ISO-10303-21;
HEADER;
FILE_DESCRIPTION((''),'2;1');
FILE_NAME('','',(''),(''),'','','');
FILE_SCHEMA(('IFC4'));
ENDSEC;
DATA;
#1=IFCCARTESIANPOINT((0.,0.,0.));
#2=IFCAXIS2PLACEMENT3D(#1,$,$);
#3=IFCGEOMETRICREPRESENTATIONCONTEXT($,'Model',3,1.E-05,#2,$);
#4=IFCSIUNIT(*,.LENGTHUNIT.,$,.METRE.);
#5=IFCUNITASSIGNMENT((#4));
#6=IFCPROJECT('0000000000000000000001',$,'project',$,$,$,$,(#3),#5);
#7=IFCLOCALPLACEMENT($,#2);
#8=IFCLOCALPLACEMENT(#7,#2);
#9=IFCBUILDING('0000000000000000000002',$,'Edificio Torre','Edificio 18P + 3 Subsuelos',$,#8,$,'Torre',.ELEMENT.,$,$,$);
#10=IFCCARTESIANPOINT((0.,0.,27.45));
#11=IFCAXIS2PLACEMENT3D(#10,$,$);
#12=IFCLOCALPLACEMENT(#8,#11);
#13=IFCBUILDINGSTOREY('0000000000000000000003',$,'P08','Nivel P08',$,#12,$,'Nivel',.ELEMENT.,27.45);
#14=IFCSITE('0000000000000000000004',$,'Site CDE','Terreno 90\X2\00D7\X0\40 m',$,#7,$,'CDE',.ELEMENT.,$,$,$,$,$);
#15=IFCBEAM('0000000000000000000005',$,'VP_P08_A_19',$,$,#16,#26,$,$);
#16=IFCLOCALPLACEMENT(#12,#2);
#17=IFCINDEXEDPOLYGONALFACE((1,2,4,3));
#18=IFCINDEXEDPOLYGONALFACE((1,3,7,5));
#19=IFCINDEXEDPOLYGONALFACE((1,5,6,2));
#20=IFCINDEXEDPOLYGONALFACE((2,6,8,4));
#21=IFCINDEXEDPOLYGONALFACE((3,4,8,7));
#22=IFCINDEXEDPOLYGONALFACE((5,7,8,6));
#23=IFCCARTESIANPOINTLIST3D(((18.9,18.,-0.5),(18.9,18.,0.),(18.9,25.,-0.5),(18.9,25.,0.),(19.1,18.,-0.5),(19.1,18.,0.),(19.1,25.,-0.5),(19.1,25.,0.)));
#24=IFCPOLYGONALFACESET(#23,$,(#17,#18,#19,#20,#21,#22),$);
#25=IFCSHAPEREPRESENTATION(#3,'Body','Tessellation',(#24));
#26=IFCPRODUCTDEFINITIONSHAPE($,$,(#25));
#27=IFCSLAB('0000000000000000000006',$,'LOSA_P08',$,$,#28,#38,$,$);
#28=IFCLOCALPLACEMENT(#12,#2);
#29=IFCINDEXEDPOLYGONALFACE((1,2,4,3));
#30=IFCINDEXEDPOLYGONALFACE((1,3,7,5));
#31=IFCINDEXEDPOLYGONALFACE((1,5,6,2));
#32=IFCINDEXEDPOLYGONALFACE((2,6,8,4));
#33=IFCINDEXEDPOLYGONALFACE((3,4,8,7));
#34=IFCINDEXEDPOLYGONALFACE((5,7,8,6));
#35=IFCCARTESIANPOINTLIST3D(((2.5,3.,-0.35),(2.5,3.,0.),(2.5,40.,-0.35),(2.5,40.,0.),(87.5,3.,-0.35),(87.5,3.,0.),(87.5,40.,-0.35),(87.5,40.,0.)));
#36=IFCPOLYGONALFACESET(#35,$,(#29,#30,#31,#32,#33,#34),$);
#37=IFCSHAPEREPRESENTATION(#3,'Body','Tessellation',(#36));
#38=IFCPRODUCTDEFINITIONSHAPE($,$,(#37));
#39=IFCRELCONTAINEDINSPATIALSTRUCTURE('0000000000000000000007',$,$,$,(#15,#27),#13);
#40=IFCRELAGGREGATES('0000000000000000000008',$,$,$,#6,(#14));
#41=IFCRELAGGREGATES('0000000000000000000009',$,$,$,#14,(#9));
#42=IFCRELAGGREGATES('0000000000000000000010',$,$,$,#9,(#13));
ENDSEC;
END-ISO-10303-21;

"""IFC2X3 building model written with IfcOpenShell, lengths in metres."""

from ifc_helpers import new_model, si_unit, frame, origin, origin_2d, place, context, project, spatial, rectangle, extrude, element, save


model = new_model("IFC2X3")

# Units and contexts
model_context = context("Model", 3, precision=1e-05, world=origin())
ifc_project = project(units=[si_unit("LENGTHUNIT", "METRE")], contexts=[model_context])

# Site, building, storey
site_placement = place(None, origin())
site = spatial("IfcSite", under=ifc_project, at=site_placement, Name="Site CDE", Description="Terreno 90×40 m", LongName="CDE", CompositionType="ELEMENT")
building_placement = place(site_placement, origin())
building = spatial("IfcBuilding", under=site, at=building_placement, Name="Edificio Torre", Description="Edificio 18P + 3 Subsuelos", LongName="Torre", CompositionType="ELEMENT")
storey_placement = place(building_placement, frame((0.0, 0.0, 27.45)))
storey = spatial("IfcBuildingStorey", under=building, at=storey_placement, Name="P08", Description="Nivel P08", LongName="Nivel", CompositionType="ELEMENT", Elevation=27.45)

# Beam
beam_1_placement = place(storey_placement, frame((19.0, 21.5, -0.5)))
element("IfcBeam", 1, at=beam_1_placement, inside=storey, Name="VP_P08_A_19", context=model_context, shape_type="SweptSolid", body=[
    extrude(rectangle(XDim=0.2, YDim=7.0, at=origin_2d()), origin(), (0.0, 0.0, 1.0), 0.5),
])

# Slab
slab_placement = place(storey_placement, frame((45.0, 21.5, -0.35)))
element("IfcSlab", 2, at=slab_placement, inside=storey, Name="LOSA_P08", context=model_context, shape_type="SweptSolid", body=[
    extrude(rectangle(XDim=85.0, YDim=37.0, at=origin_2d()), origin(), (0.0, 0.0, 1.0), 0.35),
])

save(model, "model.ifc")
